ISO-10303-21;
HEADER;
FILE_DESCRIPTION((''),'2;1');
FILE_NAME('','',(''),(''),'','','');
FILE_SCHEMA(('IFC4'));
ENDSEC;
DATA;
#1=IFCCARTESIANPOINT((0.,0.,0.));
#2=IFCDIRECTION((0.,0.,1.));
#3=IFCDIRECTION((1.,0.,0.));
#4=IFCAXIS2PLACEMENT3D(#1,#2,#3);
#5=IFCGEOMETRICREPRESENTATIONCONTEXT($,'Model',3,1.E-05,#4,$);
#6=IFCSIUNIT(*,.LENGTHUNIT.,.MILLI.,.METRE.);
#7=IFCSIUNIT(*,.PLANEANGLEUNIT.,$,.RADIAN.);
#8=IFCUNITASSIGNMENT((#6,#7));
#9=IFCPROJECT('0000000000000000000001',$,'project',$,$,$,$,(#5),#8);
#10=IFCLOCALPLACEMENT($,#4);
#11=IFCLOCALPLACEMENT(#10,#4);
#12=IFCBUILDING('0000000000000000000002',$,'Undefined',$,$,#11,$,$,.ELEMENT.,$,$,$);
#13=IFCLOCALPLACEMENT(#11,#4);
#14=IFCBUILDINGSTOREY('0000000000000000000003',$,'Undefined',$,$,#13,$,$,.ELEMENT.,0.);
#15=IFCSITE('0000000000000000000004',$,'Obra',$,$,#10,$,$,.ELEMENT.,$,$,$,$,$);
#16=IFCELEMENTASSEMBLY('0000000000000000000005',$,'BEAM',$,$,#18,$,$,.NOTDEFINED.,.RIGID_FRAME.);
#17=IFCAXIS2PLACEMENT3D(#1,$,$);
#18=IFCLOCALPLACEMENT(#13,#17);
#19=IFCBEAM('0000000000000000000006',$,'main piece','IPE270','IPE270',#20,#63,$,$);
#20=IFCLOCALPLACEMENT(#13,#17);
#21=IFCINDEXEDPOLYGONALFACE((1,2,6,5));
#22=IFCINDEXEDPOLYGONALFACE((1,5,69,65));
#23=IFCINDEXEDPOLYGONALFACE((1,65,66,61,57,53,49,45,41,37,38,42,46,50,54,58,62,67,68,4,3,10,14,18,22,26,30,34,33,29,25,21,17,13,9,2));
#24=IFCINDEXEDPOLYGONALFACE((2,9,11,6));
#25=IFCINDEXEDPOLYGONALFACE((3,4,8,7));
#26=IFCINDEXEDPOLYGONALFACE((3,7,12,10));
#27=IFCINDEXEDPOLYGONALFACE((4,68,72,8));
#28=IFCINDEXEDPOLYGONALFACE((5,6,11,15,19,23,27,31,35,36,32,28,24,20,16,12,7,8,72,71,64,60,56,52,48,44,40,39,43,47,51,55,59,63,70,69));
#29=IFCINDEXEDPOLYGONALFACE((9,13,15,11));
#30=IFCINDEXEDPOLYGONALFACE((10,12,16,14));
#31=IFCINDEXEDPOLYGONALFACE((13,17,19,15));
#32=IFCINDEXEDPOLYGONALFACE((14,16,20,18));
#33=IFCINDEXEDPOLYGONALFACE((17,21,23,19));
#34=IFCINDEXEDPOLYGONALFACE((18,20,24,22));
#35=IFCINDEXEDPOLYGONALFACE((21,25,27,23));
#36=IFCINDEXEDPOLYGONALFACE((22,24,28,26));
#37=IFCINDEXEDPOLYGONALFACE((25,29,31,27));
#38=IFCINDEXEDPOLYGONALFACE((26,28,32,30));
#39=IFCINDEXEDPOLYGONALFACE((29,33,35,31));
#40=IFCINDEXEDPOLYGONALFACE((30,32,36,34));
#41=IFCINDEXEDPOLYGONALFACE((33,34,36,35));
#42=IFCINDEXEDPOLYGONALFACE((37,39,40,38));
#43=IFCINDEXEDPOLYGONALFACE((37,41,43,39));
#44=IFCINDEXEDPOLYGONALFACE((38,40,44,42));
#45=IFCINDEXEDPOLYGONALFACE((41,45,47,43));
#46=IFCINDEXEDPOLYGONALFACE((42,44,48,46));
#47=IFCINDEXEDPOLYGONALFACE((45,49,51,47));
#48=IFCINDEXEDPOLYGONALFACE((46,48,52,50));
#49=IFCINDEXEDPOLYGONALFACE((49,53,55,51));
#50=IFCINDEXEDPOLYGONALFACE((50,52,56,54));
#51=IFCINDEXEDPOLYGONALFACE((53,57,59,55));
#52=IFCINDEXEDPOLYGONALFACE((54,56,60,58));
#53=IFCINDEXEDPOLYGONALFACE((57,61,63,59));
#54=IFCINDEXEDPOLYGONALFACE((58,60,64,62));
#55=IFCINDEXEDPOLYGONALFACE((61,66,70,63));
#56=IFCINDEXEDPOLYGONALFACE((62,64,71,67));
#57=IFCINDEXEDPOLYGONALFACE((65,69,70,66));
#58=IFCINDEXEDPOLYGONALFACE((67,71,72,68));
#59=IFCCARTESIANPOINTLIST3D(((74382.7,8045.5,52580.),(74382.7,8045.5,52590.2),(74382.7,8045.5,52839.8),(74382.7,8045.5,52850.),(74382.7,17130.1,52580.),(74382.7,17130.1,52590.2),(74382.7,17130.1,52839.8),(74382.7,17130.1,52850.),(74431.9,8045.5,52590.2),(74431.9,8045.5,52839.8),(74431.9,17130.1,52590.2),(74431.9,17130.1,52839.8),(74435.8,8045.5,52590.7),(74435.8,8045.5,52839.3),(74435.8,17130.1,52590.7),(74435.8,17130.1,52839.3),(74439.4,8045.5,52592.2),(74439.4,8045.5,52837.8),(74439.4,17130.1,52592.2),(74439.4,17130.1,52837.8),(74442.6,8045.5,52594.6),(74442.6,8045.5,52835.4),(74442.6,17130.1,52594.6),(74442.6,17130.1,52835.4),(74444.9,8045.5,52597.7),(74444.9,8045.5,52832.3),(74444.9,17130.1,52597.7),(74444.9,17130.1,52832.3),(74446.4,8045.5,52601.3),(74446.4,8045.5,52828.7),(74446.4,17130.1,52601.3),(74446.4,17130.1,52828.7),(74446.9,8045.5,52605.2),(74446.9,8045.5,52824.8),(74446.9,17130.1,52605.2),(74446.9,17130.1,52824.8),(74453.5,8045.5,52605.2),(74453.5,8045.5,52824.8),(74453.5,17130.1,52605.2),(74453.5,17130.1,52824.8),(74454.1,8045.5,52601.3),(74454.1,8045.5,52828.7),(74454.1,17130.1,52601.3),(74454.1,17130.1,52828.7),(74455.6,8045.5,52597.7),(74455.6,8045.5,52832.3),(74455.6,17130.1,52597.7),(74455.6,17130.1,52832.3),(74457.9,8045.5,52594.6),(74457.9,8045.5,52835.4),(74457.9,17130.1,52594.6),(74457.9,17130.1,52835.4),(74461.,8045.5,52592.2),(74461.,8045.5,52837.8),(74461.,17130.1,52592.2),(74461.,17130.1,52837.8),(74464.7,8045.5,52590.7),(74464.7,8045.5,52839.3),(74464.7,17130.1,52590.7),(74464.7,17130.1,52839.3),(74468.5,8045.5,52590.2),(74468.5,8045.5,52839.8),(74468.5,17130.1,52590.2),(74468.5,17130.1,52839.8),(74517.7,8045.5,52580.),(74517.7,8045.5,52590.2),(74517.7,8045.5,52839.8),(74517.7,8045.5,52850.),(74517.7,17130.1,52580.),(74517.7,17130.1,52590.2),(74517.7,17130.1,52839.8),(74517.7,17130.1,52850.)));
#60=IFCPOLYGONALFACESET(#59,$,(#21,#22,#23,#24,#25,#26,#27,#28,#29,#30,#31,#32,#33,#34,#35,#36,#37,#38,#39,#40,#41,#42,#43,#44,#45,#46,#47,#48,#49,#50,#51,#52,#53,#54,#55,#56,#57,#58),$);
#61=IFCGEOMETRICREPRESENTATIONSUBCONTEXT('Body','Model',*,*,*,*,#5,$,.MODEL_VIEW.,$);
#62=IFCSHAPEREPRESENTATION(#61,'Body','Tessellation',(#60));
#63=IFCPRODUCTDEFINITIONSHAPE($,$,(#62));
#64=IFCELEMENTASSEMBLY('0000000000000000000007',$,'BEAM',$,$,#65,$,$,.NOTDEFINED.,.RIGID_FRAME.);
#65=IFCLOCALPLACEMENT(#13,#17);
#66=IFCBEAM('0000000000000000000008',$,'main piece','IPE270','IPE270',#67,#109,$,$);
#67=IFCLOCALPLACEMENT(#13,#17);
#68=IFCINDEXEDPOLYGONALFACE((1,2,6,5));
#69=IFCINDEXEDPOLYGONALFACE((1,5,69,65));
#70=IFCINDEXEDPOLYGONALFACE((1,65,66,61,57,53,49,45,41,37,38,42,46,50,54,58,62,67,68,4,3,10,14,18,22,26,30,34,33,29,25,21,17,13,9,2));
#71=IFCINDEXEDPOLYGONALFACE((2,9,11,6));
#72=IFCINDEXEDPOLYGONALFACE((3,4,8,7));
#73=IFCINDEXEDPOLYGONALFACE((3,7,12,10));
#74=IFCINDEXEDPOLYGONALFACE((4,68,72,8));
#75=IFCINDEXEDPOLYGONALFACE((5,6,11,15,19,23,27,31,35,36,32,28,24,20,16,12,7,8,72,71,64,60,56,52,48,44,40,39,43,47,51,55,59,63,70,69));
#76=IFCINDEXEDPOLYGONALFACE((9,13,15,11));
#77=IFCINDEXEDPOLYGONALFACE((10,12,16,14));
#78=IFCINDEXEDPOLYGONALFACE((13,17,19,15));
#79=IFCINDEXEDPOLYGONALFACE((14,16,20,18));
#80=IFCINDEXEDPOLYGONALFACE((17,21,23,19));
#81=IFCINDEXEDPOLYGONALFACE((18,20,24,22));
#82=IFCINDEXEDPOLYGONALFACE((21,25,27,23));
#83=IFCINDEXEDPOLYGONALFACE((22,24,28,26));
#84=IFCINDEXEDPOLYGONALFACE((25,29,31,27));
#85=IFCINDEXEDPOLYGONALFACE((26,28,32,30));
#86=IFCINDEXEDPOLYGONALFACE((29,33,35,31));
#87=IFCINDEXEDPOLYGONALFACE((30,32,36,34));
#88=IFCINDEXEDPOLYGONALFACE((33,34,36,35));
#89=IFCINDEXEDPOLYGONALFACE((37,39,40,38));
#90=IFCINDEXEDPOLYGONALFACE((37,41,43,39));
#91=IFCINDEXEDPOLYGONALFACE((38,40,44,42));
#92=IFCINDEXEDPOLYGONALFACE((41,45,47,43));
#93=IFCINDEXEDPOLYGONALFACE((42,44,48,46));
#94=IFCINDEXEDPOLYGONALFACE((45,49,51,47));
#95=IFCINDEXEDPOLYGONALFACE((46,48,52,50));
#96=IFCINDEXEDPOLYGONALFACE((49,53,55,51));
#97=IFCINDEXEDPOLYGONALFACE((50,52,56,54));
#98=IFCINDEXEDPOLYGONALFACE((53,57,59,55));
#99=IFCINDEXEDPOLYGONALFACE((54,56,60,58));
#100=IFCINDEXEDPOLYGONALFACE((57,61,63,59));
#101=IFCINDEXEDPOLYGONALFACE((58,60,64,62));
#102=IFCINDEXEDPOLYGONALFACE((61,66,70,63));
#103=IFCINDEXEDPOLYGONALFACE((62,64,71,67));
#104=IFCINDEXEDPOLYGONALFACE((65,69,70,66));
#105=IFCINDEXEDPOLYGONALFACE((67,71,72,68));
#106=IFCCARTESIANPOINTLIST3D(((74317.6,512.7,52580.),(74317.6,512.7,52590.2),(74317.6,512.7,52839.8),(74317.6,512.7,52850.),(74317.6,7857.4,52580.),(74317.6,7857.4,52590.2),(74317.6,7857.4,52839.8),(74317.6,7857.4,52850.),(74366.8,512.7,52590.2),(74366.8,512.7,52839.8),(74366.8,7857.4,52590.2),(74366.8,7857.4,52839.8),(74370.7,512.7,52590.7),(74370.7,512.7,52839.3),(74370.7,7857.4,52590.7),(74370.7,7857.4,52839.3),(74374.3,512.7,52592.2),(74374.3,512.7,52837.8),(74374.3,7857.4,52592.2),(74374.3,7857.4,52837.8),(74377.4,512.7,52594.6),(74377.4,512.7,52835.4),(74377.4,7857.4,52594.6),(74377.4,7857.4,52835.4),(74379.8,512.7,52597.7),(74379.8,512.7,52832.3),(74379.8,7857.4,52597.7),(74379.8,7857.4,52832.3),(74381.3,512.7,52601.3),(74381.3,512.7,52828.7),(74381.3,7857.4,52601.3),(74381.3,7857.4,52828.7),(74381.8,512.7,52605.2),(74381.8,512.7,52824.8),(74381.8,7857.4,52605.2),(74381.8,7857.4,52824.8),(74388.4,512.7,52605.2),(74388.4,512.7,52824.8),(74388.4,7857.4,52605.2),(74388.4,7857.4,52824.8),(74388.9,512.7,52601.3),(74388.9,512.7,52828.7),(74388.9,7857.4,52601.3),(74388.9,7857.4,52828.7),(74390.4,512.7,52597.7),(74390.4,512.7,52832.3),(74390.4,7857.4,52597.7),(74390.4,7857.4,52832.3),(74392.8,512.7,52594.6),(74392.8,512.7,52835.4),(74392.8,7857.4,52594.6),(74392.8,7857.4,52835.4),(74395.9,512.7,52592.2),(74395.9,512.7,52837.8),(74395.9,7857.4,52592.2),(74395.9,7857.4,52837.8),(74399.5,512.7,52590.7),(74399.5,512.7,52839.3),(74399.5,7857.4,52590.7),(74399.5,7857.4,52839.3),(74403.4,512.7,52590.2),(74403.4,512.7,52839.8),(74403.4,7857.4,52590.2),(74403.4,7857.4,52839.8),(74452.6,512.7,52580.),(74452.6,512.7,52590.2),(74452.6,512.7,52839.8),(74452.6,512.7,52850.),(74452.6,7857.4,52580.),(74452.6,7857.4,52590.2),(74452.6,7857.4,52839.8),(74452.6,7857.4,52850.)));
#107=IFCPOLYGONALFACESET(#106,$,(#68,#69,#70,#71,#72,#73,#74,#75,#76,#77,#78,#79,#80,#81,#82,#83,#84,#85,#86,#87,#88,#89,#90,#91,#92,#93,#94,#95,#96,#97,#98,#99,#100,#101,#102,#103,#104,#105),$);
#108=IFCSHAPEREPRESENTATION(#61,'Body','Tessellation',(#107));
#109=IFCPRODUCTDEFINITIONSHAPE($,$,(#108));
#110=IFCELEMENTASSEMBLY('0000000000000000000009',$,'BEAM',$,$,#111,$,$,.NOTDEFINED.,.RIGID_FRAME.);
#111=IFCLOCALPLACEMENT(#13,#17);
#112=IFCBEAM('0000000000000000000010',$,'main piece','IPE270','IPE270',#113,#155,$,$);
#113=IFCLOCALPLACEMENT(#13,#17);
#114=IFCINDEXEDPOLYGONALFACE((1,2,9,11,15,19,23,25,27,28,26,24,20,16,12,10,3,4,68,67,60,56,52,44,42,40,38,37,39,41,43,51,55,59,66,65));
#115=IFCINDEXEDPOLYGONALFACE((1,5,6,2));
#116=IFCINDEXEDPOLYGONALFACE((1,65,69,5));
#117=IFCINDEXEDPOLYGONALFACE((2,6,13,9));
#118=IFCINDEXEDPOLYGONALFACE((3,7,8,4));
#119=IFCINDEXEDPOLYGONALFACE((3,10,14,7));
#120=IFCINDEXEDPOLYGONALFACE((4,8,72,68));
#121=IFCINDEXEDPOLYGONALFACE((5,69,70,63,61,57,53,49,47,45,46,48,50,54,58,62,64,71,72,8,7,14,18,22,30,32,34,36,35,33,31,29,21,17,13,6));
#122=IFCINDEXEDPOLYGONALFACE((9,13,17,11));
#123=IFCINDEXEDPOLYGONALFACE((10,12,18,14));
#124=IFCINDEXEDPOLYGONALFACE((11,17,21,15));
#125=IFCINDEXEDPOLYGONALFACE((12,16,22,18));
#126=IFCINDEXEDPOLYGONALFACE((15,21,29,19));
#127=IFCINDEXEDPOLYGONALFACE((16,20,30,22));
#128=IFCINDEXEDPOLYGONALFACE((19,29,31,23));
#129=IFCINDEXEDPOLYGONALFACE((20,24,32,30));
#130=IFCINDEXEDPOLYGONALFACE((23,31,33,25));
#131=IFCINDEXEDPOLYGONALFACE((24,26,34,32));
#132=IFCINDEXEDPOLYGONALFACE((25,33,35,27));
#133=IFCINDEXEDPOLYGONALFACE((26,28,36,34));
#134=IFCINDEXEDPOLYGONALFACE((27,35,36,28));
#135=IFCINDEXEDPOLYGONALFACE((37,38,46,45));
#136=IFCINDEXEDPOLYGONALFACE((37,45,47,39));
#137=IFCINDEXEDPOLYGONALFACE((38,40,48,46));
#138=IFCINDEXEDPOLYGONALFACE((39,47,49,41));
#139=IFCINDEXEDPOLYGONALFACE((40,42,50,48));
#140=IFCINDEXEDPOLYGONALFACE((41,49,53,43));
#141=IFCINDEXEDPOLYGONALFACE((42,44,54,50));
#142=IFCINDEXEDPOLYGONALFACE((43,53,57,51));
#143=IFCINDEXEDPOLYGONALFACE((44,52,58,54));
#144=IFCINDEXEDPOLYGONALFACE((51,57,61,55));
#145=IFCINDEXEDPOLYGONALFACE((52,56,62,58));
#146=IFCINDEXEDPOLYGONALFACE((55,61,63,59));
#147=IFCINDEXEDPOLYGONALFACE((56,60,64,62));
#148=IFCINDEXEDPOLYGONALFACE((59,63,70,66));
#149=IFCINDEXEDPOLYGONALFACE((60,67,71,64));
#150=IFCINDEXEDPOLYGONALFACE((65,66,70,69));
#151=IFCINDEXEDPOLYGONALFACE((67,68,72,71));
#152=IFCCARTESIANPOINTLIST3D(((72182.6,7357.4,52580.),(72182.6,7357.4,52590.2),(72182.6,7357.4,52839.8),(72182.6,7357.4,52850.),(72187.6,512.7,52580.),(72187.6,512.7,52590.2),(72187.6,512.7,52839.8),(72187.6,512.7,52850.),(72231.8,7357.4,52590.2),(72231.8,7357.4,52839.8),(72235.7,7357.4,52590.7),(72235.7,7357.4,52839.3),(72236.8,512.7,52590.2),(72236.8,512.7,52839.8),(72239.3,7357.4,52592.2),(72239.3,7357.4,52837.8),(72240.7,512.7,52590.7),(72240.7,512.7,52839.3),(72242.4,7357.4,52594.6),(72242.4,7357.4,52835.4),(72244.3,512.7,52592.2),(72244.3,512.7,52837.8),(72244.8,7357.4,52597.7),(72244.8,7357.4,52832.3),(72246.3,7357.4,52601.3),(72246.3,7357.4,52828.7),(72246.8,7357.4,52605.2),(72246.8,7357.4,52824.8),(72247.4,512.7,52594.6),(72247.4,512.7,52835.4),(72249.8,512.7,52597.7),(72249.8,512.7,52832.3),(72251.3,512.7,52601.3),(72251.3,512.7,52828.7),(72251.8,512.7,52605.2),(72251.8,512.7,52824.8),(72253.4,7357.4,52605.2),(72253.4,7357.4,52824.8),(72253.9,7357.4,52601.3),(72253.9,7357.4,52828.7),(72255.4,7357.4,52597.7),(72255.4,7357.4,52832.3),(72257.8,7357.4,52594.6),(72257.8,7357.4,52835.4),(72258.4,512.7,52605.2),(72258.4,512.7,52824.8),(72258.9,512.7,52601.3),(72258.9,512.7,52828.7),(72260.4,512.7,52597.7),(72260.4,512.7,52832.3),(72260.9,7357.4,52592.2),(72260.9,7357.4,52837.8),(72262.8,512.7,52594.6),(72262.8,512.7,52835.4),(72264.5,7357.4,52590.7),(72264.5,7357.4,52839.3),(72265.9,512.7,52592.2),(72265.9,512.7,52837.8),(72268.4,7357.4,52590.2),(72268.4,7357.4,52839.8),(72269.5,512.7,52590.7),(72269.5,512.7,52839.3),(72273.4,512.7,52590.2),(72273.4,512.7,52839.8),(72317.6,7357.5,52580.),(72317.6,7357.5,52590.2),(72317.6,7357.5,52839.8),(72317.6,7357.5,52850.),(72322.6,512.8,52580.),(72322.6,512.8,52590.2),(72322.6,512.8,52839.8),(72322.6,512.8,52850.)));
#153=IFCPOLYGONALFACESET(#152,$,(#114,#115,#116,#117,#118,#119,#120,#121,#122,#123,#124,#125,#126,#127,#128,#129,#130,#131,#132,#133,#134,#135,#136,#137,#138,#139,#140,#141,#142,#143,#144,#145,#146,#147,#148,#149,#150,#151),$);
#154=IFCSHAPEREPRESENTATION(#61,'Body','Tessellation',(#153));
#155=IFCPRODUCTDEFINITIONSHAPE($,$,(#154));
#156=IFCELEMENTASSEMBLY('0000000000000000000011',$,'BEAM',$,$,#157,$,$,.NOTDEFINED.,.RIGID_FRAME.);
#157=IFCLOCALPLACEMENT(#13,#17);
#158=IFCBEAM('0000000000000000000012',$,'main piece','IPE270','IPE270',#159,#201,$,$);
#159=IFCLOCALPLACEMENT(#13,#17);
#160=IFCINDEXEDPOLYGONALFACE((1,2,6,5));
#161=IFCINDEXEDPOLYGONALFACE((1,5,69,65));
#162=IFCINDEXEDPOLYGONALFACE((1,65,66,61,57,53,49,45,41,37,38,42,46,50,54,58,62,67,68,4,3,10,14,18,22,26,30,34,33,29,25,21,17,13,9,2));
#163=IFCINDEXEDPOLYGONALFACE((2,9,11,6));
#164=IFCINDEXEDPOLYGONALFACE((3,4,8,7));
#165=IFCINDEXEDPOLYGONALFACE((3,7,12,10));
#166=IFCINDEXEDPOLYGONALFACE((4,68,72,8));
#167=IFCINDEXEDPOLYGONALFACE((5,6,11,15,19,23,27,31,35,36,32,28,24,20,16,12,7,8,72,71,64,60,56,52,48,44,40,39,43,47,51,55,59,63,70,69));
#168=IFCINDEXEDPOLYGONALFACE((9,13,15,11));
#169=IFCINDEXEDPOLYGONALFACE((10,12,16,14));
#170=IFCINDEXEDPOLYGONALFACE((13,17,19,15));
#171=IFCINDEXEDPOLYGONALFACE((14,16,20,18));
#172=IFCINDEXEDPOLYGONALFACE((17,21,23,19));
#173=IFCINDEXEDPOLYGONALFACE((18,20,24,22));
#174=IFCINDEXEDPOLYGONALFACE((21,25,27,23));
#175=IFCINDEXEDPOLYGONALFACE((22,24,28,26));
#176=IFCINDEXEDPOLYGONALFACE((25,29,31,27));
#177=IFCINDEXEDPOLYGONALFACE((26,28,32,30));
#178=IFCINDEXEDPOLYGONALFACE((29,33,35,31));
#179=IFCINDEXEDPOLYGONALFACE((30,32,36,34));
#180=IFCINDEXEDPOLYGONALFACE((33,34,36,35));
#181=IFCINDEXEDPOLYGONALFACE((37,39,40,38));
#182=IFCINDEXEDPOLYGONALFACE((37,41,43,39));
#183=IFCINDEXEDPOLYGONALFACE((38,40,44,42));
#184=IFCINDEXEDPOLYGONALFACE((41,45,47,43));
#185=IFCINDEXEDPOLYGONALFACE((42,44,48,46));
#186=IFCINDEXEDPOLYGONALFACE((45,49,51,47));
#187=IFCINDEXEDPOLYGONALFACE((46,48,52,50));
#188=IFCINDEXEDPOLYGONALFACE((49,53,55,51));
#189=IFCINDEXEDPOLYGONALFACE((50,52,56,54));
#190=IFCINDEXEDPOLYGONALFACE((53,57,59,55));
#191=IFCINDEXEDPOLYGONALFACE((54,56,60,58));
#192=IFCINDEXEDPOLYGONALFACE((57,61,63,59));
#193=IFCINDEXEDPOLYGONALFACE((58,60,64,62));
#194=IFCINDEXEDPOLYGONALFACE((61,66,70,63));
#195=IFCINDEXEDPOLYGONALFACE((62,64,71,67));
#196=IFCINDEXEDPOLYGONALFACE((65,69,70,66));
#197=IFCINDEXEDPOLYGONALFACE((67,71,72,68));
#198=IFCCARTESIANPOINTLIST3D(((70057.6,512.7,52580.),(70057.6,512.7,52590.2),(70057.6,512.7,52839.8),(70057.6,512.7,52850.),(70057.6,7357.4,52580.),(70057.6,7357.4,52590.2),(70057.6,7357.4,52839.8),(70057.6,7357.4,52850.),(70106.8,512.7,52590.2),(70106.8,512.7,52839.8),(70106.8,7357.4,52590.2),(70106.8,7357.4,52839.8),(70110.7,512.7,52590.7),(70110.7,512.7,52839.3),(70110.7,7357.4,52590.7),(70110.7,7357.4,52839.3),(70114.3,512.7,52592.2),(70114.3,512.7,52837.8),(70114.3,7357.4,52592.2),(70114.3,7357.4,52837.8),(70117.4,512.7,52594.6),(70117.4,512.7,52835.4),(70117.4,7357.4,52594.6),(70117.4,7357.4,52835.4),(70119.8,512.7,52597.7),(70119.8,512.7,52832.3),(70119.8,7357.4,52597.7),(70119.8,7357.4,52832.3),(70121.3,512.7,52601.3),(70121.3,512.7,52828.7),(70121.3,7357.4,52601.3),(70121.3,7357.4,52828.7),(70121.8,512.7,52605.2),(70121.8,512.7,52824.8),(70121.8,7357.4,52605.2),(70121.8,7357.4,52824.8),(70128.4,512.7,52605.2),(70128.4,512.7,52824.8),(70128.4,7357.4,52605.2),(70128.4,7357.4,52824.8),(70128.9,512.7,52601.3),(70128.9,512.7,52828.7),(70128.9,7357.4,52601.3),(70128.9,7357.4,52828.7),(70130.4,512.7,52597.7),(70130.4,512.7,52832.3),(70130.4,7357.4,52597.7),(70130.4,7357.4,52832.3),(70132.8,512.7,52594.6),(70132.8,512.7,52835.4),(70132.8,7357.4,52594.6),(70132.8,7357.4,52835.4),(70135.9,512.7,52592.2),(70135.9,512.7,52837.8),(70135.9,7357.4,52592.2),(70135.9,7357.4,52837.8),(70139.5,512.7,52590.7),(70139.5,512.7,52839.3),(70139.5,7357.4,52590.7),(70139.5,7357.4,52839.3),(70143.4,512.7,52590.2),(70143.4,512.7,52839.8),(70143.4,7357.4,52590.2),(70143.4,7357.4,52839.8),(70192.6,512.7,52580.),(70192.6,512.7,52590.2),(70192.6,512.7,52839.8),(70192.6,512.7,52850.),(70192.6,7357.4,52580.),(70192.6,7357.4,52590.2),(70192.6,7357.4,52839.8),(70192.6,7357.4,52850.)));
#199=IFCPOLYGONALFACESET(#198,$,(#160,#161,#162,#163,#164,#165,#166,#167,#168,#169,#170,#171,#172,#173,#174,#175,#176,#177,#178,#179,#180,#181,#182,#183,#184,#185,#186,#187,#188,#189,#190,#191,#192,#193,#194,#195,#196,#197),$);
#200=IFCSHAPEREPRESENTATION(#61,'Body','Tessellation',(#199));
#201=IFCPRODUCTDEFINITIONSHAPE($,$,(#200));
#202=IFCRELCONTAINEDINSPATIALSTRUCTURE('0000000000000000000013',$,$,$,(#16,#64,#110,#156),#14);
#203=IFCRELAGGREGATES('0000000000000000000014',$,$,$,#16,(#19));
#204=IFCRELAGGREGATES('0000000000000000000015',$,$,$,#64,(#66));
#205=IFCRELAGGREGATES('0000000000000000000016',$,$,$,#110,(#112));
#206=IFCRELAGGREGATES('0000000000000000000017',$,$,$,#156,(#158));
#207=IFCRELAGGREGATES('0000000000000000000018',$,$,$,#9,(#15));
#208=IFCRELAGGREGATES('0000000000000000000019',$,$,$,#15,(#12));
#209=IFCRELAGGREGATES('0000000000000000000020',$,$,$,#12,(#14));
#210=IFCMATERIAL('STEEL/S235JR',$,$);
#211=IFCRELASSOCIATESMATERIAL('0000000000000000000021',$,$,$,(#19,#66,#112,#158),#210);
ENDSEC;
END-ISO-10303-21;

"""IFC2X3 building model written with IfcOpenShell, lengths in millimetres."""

from ifc_helpers import new_model, si_unit, frame, origin_with_axes, origin_2d_with_axis, place, context, subcontext, project, spatial, i_section, extrude, material, element, aggregate, save


model = new_model("IFC2X3")

# Units and contexts
model_context = context("Model", 3, precision=1e-05, world=origin_with_axes())
body_context = subcontext(model_context, "Body", "Model", "MODEL_VIEW")
ifc_project = project(units=[si_unit("LENGTHUNIT", "METRE", prefix="MILLI"), si_unit("PLANEANGLEUNIT", "RADIAN")], contexts=[model_context])

# Site, building, storey
site_placement = place(None, origin_with_axes())
site = spatial("IfcSite", under=ifc_project, at=site_placement, Name="Obra", CompositionType="ELEMENT")
building_placement = place(site_placement, origin_with_axes())
building = spatial("IfcBuilding", under=site, at=building_placement, Name="Undefined", CompositionType="ELEMENT")
storey_placement = place(building_placement, origin_with_axes())
storey = spatial("IfcBuildingStorey", under=building, at=storey_placement, Name="Undefined", CompositionType="ELEMENT", Elevation=0.0)

# Shared definitions
ifc_material_1 = material(Name="STEEL/S235JR")

# Element assemblies, beams
assembly_1_placement = place(storey_placement, origin_with_axes())
assembly_1 = element("IfcElementAssembly", 1, at=assembly_1_placement, inside=storey, Name="BEAM", AssemblyPlace="NOTDEFINED", PredefinedType="RIGID_FRAME")
beam_1_placement = place(assembly_1_placement, frame((74450.2, 8045.5, 52715.0), z_axis=(0.0, 0.0, 1.0), x_axis=(0.0, 1.0, 0.0)))
beam_1 = element("IfcBeam", 2, at=beam_1_placement, material=ifc_material_1, Name="main piece", Description="IPE270", ObjectType="IPE270", context=body_context, shape_type="SweptSolid", body=[
    extrude(i_section(OverallWidth=135.0, OverallDepth=270.0, WebThickness=6.6, FlangeThickness=10.2, FilletRadius=15.0, at=origin_2d_with_axis()), frame((9084.6, 0.0, 0.0), z_axis=(-1.0, 0.0, 0.0), x_axis=(0.0, -1.0, 0.0)), (0.0, 0.0, 1.0), 9084.6),
])
aggregate(assembly_1, [beam_1])
assembly_2_placement = place(storey_placement, origin_with_axes())
assembly_2 = element("IfcElementAssembly", 3, at=assembly_2_placement, inside=storey, Name="BEAM", AssemblyPlace="NOTDEFINED", PredefinedType="RIGID_FRAME")
beam_2_placement = place(assembly_2_placement, frame((74385.1, 512.7, 52715.0), z_axis=(0.0, 0.0, 1.0), x_axis=(0.0, 1.0, 0.0)))
beam_2 = element("IfcBeam", 4, at=beam_2_placement, material=ifc_material_1, Name="main piece", Description="IPE270", ObjectType="IPE270", context=body_context, shape_type="SweptSolid", body=[
    extrude(i_section(OverallWidth=135.0, OverallDepth=270.0, WebThickness=6.6, FlangeThickness=10.2, FilletRadius=15.0, at=origin_2d_with_axis()), frame((7344.7, 0.0, 0.0), z_axis=(-1.0, 0.0, 0.0), x_axis=(0.0, -1.0, 0.0)), (0.0, 0.0, 1.0), 7344.7),
])
aggregate(assembly_2, [beam_2])
assembly_3_placement = place(storey_placement, origin_with_axes())
assembly_3 = element("IfcElementAssembly", 5, at=assembly_3_placement, inside=storey, Name="BEAM", AssemblyPlace="NOTDEFINED", PredefinedType="RIGID_FRAME")
beam_3_placement = place(assembly_3_placement, frame((72250.1, 7357.4, 52715.0), z_axis=(0.0, 0.0, 1.0), x_axis=(0.000731, -1.0, 0.0)))
beam_3 = element("IfcBeam", 6, at=beam_3_placement, material=ifc_material_1, Name="main piece", Description="IPE270", ObjectType="IPE270", context=body_context, shape_type="SweptSolid", body=[
    extrude(i_section(OverallWidth=135.0, OverallDepth=270.0, WebThickness=6.6, FlangeThickness=10.2, FilletRadius=15.0, at=origin_2d_with_axis()), frame((6844.7, 0.0, 0.0), z_axis=(-1.0, 0.0, 0.0), x_axis=(0.0, -1.0, 0.0)), (0.0, 0.0, 1.0), 6844.7),
])
aggregate(assembly_3, [beam_3])
assembly_4_placement = place(storey_placement, origin_with_axes())
assembly_4 = element("IfcElementAssembly", 7, at=assembly_4_placement, inside=storey, Name="BEAM", AssemblyPlace="NOTDEFINED", PredefinedType="RIGID_FRAME")
beam_4_placement = place(assembly_4_placement, frame((70125.1, 512.7, 52715.0), z_axis=(0.0, 0.0, 1.0), x_axis=(0.0, 1.0, 0.0)))
beam_4 = element("IfcBeam", 8, at=beam_4_placement, material=ifc_material_1, Name="main piece", Description="IPE270", ObjectType="IPE270", context=body_context, shape_type="SweptSolid", body=[
    extrude(i_section(OverallWidth=135.0, OverallDepth=270.0, WebThickness=6.6, FlangeThickness=10.2, FilletRadius=15.0, at=origin_2d_with_axis()), frame((6844.7, 0.0, 0.0), z_axis=(-1.0, 0.0, 0.0), x_axis=(0.0, -1.0, 0.0)), (0.0, 0.0, 1.0), 6844.7),
])
aggregate(assembly_4, [beam_4])

save(model, "model.ifc")
